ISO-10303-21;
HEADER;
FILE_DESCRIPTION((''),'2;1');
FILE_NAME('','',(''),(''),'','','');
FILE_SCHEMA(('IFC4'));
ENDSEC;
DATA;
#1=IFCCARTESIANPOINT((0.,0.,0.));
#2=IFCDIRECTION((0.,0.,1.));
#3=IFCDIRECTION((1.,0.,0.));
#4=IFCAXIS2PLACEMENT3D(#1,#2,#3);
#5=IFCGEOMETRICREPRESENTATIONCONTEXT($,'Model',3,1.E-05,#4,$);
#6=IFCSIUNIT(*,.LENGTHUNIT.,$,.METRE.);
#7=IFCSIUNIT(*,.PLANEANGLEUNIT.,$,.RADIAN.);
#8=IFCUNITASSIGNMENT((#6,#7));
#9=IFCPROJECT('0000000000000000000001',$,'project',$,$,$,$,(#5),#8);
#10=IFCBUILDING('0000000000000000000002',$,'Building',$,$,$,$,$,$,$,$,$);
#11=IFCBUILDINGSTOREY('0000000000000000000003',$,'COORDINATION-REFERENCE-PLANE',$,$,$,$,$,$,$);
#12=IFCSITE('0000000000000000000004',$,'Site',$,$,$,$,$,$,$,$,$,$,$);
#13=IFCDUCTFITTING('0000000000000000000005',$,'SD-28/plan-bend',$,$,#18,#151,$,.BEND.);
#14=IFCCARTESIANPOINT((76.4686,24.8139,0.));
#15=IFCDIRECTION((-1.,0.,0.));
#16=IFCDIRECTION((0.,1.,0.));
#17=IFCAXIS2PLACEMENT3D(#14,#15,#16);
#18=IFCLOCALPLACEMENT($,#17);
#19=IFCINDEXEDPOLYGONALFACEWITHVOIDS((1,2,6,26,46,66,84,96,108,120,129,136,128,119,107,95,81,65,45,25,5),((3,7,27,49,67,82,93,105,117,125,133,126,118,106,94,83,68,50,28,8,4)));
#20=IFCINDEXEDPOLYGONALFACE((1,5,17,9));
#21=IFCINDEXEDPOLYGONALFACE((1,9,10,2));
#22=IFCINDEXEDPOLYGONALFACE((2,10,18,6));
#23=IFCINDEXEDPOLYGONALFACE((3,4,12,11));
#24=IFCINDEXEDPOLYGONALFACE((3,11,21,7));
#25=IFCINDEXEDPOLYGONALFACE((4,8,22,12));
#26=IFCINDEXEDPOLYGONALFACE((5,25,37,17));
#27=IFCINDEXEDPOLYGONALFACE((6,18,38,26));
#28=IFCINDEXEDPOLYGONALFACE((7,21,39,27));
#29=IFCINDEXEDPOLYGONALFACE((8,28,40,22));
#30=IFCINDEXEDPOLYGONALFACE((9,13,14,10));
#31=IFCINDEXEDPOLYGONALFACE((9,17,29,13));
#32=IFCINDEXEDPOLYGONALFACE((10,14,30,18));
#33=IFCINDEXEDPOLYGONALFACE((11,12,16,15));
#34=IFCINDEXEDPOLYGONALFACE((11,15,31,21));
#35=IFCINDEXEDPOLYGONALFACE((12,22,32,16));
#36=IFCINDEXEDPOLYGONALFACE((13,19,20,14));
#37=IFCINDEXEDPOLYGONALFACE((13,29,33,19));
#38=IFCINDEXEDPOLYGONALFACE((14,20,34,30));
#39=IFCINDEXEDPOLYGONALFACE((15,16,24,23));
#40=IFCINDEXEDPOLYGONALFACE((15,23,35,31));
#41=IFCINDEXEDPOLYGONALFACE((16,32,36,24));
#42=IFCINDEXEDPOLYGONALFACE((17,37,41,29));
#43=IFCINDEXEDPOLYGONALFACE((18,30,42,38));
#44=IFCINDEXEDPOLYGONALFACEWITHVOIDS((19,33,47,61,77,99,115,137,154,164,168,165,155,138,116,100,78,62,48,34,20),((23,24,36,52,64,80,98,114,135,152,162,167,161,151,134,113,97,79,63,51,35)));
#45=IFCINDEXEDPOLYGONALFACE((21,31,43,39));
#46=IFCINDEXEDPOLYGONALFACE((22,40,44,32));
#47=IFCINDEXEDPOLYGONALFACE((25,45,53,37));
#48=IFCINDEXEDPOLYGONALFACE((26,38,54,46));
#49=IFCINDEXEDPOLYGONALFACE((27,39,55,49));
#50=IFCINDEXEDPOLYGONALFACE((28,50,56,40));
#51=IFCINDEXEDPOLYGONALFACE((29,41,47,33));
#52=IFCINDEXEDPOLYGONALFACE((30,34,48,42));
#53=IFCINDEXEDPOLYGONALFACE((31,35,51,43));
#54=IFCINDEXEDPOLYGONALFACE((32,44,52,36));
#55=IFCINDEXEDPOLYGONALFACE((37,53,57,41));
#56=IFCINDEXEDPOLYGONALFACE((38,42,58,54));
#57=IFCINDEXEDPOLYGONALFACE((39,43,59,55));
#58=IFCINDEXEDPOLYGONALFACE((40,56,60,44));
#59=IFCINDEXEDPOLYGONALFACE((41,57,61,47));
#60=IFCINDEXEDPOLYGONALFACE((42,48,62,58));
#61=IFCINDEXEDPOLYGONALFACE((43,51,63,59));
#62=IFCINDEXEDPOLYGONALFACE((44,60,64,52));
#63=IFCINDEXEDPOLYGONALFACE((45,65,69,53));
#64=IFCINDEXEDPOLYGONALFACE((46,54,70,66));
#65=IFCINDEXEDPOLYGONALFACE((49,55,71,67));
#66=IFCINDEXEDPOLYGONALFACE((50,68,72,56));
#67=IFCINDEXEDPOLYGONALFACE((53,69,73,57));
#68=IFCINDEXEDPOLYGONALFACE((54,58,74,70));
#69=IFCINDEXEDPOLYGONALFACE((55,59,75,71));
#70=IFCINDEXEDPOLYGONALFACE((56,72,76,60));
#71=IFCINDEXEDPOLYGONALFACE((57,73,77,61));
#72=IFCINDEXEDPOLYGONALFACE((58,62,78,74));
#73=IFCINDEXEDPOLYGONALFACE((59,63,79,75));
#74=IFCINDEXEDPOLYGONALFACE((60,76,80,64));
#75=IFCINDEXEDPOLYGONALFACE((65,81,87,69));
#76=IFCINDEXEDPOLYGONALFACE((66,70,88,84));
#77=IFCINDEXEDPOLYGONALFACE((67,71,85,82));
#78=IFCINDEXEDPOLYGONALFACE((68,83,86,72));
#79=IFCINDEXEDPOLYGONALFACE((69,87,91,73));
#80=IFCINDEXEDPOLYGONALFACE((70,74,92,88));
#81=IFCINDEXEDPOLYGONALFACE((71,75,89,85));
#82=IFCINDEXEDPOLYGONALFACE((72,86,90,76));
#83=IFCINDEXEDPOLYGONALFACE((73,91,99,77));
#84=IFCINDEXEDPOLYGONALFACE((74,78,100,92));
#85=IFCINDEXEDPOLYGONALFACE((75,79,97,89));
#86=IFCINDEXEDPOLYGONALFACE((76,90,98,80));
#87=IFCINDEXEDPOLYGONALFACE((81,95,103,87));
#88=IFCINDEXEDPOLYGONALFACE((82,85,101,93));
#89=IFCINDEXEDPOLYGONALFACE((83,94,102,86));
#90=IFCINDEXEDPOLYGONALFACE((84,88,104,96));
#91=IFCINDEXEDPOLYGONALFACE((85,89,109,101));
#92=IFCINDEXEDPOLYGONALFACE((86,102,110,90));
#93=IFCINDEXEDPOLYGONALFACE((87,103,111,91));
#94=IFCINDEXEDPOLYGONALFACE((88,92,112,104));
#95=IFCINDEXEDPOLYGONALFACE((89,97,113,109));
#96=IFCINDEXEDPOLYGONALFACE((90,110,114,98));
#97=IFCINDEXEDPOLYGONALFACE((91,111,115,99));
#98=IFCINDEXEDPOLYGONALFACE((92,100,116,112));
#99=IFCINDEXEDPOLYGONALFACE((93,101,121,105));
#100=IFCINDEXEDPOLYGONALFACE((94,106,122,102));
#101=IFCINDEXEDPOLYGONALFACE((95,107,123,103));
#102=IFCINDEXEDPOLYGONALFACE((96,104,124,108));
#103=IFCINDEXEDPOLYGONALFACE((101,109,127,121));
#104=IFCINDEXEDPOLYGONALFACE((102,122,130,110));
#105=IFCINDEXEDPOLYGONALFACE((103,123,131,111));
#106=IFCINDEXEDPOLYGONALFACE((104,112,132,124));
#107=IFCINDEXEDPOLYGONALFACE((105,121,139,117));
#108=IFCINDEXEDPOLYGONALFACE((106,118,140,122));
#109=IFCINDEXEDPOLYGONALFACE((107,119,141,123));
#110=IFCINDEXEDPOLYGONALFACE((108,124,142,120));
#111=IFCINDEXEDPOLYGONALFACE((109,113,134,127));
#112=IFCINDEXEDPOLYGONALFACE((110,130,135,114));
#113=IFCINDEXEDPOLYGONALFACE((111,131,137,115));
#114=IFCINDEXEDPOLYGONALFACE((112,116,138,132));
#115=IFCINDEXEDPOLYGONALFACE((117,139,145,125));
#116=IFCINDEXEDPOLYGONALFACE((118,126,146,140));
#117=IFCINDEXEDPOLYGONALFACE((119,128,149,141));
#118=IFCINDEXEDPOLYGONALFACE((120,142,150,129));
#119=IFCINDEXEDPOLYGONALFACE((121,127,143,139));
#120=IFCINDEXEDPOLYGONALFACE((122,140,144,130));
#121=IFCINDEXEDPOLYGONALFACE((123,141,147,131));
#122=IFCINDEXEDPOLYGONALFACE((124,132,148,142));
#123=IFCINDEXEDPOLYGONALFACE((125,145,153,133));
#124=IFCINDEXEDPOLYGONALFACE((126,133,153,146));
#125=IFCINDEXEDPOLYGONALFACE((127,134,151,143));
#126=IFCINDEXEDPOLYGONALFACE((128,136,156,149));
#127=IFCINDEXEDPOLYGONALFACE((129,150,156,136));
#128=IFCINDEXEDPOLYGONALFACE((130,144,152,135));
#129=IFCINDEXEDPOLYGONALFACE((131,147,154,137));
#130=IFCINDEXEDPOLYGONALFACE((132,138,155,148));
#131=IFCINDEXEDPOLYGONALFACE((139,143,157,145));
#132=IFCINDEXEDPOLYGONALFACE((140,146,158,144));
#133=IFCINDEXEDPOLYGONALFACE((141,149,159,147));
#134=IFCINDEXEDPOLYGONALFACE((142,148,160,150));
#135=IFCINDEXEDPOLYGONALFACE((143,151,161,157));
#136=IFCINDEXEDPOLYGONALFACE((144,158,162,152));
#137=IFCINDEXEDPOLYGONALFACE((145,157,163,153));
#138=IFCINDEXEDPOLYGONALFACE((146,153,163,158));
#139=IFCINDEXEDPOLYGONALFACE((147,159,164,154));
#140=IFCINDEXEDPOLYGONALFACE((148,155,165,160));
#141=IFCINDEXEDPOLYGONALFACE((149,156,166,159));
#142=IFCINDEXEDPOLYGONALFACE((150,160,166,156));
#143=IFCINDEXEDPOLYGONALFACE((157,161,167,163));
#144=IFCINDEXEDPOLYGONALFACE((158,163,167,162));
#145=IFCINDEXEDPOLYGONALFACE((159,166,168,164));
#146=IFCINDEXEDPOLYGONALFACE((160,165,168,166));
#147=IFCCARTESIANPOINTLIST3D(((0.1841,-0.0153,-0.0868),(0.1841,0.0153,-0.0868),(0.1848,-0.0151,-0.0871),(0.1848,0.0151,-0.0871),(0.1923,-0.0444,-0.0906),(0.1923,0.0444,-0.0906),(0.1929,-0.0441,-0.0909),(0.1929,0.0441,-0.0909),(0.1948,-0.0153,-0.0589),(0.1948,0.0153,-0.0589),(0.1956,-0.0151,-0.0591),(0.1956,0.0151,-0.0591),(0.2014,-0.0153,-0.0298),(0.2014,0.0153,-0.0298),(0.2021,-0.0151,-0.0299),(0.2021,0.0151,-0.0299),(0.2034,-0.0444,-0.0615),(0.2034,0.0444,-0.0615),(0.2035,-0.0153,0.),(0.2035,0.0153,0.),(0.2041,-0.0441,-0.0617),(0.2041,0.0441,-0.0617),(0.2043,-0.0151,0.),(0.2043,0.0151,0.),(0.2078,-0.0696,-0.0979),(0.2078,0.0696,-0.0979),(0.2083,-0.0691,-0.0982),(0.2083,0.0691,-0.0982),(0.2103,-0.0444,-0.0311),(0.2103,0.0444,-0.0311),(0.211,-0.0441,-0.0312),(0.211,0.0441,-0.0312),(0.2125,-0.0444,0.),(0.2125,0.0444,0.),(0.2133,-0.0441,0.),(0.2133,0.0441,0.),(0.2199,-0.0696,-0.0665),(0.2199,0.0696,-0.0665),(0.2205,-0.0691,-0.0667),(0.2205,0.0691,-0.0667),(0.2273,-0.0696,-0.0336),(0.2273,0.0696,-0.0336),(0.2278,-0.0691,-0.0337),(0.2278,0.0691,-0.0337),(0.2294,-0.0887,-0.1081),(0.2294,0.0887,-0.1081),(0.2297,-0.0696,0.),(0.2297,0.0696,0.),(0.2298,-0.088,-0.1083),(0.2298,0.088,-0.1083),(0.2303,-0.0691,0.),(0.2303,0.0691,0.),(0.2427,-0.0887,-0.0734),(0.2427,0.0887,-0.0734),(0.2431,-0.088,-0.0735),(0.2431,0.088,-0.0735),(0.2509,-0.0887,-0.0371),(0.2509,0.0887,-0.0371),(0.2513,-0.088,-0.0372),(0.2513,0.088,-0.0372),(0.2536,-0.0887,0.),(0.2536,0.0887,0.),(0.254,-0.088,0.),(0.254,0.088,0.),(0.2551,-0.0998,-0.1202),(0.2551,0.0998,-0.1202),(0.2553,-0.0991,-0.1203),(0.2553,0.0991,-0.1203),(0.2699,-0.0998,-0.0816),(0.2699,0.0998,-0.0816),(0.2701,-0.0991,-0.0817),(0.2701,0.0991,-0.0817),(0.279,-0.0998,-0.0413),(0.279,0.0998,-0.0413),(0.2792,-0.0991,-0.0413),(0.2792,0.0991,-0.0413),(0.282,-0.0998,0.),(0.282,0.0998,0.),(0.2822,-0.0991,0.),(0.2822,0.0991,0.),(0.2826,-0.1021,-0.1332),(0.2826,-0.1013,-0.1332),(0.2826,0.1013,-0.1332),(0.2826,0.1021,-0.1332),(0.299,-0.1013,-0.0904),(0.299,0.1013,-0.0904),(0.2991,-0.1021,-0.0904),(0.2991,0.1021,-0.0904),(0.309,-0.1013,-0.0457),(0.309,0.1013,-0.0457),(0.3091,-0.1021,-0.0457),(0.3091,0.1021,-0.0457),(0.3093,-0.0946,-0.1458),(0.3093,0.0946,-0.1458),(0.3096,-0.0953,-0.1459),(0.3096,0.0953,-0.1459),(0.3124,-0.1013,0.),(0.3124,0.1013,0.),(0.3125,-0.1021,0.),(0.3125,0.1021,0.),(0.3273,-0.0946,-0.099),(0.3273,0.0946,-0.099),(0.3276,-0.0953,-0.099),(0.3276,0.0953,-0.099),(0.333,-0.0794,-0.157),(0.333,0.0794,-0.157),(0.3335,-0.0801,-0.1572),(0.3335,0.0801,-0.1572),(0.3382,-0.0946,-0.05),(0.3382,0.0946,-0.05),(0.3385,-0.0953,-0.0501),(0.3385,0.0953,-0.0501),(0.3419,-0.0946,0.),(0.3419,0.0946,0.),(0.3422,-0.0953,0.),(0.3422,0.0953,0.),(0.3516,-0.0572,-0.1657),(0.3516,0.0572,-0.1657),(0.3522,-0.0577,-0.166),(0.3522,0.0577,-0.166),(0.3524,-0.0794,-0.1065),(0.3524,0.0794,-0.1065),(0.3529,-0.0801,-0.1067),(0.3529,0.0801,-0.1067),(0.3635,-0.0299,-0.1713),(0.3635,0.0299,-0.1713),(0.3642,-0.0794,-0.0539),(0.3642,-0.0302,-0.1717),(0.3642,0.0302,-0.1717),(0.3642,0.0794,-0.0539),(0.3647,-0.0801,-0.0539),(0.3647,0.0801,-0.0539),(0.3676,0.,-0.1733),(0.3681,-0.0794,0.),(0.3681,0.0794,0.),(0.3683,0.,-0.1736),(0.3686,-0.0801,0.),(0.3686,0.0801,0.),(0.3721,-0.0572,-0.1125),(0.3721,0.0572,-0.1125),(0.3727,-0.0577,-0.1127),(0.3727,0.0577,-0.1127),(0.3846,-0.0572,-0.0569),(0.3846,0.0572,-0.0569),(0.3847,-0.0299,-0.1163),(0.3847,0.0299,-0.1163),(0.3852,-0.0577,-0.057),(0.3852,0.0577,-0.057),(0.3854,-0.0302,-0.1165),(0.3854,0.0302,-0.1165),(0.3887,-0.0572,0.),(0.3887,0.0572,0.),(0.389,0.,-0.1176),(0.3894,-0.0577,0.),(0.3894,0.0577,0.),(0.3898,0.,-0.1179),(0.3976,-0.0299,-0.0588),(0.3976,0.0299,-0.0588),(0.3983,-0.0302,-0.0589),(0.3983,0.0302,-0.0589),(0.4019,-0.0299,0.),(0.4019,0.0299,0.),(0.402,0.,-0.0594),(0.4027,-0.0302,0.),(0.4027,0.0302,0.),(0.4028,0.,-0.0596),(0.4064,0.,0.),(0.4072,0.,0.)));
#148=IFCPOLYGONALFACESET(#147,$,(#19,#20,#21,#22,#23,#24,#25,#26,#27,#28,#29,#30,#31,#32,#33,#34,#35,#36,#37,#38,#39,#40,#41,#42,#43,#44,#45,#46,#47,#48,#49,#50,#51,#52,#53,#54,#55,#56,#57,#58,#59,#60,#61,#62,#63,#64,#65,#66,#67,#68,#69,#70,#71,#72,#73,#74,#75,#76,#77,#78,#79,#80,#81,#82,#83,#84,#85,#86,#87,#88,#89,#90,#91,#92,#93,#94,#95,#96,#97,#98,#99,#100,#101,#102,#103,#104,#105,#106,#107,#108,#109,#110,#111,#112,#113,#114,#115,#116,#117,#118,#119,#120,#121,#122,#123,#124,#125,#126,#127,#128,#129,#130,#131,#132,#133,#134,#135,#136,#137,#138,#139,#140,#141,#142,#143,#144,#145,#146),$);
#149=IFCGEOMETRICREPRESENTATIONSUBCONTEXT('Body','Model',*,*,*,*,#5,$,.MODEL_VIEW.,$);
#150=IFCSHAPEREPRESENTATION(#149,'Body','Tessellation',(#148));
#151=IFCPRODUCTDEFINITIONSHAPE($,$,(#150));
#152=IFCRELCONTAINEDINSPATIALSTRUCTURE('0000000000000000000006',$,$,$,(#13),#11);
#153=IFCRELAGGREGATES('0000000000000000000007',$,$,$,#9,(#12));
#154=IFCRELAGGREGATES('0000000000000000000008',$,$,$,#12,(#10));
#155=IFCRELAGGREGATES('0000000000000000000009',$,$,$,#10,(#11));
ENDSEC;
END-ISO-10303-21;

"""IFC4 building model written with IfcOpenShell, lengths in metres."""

from ifc_helpers import new_model, entity, si_unit, frame, origin_with_axes, place, context, subcontext, project, spatial, element, save


model = new_model("IFC4")

# Units and contexts
model_context = context("Model", 3, precision=1e-05, world=origin_with_axes())
body_context_1 = subcontext(model_context, "Body", "Model", "MODEL_VIEW")
ifc_project = project(units=[si_unit("LENGTHUNIT", "METRE"), si_unit("PLANEANGLEUNIT", "RADIAN")], contexts=[model_context])

# Site, building, storey
site = spatial("IfcSite", under=ifc_project, Name="Site")
building = spatial("IfcBuilding", under=site, Name="Building")
storey = spatial("IfcBuildingStorey", under=building, Name="COORDINATION-REFERENCE-PLANE")

# Duct fitting
duct_fitting_1_placement = place(None, frame((76.4686, 24.8139, 0.0), z_axis=(-1.0, 0.0, 0.0), x_axis=(0.0, 1.0, 0.0)))
element("IfcDuctFitting", 1, at=duct_fitting_1_placement, inside=storey, Name="SD-28/plan-bend", PredefinedType="BEND", context=body_context_1, shape_type="SweptSolid", body=[
    entity("IfcRevolvedAreaSolid", entity("IfcCircleHollowProfileDef", "AREA", None, entity("IfcAxis2Placement2D", entity("IfcCartesianPoint", [0.3048, 0.0])), 0.1024, 0.0008), entity("IfcAxis2Placement3D", entity("IfcCartesianPoint", [0.0, 0.0, 0.0]), entity("IfcDirection", [0.0, 0.0, 1.0]), entity("IfcDirection", [1.0, 0.0, 0.0])), entity("IfcAxis1Placement", entity("IfcCartesianPoint", [0.0, 0.0, 0.0]), entity("IfcDirection", [0.0, 1.0, 0.0])), 0.440428),
])

save(model, "model.ifc")
